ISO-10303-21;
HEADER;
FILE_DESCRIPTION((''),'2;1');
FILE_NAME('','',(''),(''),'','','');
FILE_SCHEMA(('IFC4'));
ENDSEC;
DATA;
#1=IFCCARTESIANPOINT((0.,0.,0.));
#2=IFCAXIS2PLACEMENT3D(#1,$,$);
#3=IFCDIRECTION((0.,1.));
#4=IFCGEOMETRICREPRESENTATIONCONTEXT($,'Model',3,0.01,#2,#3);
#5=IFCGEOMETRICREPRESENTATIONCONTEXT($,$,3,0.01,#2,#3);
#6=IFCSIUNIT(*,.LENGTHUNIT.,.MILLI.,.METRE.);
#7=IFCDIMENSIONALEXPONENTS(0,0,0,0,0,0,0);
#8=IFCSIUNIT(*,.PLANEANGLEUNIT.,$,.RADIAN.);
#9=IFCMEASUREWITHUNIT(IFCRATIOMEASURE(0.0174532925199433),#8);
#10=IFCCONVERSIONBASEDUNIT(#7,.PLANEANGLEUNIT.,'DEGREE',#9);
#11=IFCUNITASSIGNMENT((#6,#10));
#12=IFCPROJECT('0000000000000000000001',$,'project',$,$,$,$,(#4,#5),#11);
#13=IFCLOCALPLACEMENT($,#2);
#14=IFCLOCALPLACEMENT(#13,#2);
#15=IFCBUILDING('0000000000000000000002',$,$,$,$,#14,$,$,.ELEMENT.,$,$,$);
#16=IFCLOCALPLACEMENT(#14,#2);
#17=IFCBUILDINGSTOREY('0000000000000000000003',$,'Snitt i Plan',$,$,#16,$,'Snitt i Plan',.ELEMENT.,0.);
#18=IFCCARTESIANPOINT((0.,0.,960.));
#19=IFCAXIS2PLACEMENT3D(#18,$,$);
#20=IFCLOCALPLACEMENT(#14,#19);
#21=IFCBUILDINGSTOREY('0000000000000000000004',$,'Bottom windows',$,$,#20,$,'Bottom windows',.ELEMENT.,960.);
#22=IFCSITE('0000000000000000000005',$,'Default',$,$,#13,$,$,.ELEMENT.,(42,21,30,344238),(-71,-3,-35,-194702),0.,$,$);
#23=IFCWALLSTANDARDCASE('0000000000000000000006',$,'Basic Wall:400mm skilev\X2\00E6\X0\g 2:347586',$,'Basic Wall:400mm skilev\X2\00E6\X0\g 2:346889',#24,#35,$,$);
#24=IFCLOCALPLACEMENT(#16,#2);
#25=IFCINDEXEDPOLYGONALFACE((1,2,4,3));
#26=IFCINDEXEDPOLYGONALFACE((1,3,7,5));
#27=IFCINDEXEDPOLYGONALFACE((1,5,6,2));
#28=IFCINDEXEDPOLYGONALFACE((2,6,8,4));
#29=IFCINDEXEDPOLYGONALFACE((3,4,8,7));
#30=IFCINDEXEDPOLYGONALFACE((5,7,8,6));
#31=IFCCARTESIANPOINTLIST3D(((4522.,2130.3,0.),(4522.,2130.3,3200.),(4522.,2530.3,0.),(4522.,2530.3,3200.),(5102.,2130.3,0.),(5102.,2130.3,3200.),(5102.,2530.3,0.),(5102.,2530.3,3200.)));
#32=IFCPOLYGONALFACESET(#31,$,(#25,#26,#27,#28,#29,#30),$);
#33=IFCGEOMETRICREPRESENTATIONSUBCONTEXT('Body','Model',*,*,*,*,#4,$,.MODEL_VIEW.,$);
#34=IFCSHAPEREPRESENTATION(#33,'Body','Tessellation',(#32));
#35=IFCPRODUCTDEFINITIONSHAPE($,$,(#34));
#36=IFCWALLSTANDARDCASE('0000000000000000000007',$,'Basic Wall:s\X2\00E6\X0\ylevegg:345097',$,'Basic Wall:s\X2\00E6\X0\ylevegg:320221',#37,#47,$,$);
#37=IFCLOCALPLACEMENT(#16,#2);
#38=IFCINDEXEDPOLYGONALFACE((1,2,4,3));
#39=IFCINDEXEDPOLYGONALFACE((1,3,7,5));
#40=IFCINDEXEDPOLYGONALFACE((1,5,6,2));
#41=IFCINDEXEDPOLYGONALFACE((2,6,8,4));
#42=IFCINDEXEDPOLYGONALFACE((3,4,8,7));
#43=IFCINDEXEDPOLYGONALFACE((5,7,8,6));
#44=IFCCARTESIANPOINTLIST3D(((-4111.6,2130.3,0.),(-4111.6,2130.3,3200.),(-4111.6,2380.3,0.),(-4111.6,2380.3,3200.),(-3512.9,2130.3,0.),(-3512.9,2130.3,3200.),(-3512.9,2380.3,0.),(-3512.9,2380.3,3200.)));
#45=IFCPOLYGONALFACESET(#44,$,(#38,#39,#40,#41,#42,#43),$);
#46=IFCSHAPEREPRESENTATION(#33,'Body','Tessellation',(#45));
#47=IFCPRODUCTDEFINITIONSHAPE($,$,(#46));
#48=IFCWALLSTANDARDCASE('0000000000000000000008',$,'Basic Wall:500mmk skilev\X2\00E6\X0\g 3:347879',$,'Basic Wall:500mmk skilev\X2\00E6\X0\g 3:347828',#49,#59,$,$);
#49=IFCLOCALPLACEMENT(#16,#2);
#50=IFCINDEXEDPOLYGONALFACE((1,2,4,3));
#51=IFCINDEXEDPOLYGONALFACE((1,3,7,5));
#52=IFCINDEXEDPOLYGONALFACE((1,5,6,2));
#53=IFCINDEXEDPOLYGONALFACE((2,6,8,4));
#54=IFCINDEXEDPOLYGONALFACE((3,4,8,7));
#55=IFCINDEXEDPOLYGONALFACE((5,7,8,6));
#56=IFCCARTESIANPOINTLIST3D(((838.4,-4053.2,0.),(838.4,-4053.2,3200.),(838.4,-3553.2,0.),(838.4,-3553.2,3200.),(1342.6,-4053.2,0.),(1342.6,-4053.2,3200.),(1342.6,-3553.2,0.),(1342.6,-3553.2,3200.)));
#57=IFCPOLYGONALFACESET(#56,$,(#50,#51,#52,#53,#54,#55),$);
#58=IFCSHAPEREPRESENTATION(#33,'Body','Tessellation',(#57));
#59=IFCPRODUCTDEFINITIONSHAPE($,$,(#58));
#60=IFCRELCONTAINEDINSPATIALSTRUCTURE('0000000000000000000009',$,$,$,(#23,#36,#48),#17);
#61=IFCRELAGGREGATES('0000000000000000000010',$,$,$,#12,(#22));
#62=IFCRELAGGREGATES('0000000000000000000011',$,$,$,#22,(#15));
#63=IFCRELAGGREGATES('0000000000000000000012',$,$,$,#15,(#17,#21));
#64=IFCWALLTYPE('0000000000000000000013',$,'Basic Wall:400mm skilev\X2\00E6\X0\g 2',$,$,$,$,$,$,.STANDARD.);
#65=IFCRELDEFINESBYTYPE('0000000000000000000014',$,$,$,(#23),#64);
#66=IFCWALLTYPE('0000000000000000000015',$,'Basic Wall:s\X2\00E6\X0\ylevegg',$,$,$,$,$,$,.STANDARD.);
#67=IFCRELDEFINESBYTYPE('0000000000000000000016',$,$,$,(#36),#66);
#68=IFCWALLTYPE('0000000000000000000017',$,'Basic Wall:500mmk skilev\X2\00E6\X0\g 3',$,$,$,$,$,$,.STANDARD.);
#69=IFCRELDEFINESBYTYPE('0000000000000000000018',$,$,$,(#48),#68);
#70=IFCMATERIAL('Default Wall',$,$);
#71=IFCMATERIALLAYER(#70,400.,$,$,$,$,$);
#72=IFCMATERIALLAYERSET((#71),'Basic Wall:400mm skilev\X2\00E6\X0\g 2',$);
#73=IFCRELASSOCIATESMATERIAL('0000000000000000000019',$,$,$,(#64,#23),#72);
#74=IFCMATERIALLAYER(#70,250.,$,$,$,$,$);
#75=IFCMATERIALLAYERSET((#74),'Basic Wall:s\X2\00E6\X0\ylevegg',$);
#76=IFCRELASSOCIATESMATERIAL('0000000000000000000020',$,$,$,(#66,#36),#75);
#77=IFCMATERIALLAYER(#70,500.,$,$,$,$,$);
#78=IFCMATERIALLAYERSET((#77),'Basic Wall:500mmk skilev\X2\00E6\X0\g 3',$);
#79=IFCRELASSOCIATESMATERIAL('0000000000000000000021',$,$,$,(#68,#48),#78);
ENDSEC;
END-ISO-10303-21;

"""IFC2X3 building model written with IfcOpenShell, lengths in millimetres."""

from ifc_helpers import new_model, entity, si_unit, converted_unit, direction, frame, frame_2d, origin, place, context, subcontext, project, spatial, rectangle, extrude, material, layer, layer_set, layer_usage, type_object, element, save


model = new_model("IFC2X3")

# Units and contexts
model_context = context("Model", 3, precision=0.01, world=origin(), true_north=direction((0.0, 1.0)))
context_of_model = context(None, 3, precision=0.01, world=origin(), true_north=direction((0.0, 1.0)))
body_context = subcontext(model_context, "Body", "Model", "MODEL_VIEW")
ifc_project = project(units=[si_unit("LENGTHUNIT", "METRE", prefix="MILLI"), converted_unit("PLANEANGLEUNIT", "DEGREE", entity("IfcRatioMeasure", 0.0174532925199433), si_unit("PLANEANGLEUNIT", "RADIAN"), dimensions=[0, 0, 0, 0, 0, 0, 0])], contexts=[model_context, context_of_model])

# Site, building, storey
site_placement = place(None, origin())
site = spatial("IfcSite", under=ifc_project, at=site_placement, Name="Default", CompositionType="ELEMENT", RefLatitude=(42, 21, 30, 344238), RefLongitude=(-71, -3, -35, -194702), RefElevation=0.0)
building_placement = place(site_placement, origin())
building = spatial("IfcBuilding", under=site, at=building_placement, CompositionType="ELEMENT")
storey_1_placement = place(building_placement, origin())
storey_1 = spatial("IfcBuildingStorey", under=building, at=storey_1_placement, Name="Snitt i Plan", LongName="Snitt i Plan", CompositionType="ELEMENT", Elevation=0.0)

# Shared definitions
storey_2_placement = place(building_placement, frame((0.0, 0.0, 960.0)))
storey_2 = spatial("IfcBuildingStorey", under=building, at=storey_2_placement, Name="Bottom windows", LongName="Bottom windows", CompositionType="ELEMENT", Elevation=960.0)

# Walls
ifc_material_1 = material(Name="Default Wall")
ifc_layer_1 = layer(ifc_material_1, 400.0)
ifc_layer_set_1 = layer_set([ifc_layer_1], Name="Basic Wall:400mm skilevæg 2")
wall_type_1 = type_object("IfcWallType", Name="Basic Wall:400mm skilevæg 2", PredefinedType="STANDARD", material=ifc_layer_set_1)
ifc_layer_usage_1 = layer_usage(ifc_layer_set_1, "AXIS2", "NEGATIVE", 200.0)
wall_1_placement = place(storey_1_placement, frame((5102.0, 2330.3, 0.0), z_axis=(0.0, 0.0, 1.0), x_axis=(-1.0, 0.0, 0.0)))
element("IfcWallStandardCase", 1, at=wall_1_placement, inside=storey_1, type_object=wall_type_1, material=ifc_layer_usage_1, Name="Basic Wall:400mm skilevæg 2:347586", ObjectType="Basic Wall:400mm skilevæg 2:346889", context=body_context, shape_type="SweptSolid", body=[
    extrude(rectangle(XDim=580.0, YDim=400.0, at=frame_2d((290.0, 0.0), x_axis=(-1.0, 0.0))), origin(), (0.0, 0.0, 1.0), 3200.0),
])
ifc_layer_2 = layer(ifc_material_1, 250.0)
ifc_layer_set_2 = layer_set([ifc_layer_2], Name="Basic Wall:sæylevegg")
ifc_layer_usage_2 = layer_usage(ifc_layer_set_2, "AXIS2", "NEGATIVE", 125.0)
wall_type_2 = type_object("IfcWallType", Name="Basic Wall:sæylevegg", PredefinedType="STANDARD", material=ifc_layer_set_2)
wall_2_placement = place(storey_1_placement, frame((-4111.6, 2255.3, 0.0)))
element("IfcWallStandardCase", 2, at=wall_2_placement, inside=storey_1, type_object=wall_type_2, material=ifc_layer_usage_2, Name="Basic Wall:sæylevegg:345097", ObjectType="Basic Wall:sæylevegg:320221", context=body_context, shape_type="SweptSolid", body=[
    extrude(rectangle(XDim=598.7, YDim=250.0, at=frame_2d((299.3, 0.0), x_axis=(-1.0, 0.0))), origin(), (0.0, 0.0, 1.0), 3200.0),
])
ifc_layer_3 = layer(ifc_material_1, 500.0)
ifc_layer_set_3 = layer_set([ifc_layer_3], Name="Basic Wall:500mmk skilevæg 3")
ifc_layer_usage_3 = layer_usage(ifc_layer_set_3, "AXIS2", "NEGATIVE", 250.0)
wall_type_3 = type_object("IfcWallType", Name="Basic Wall:500mmk skilevæg 3", PredefinedType="STANDARD", material=ifc_layer_set_3)
wall_3_placement = place(storey_1_placement, frame((838.4, -3803.2, 0.0)))
element("IfcWallStandardCase", 3, at=wall_3_placement, inside=storey_1, type_object=wall_type_3, material=ifc_layer_usage_3, Name="Basic Wall:500mmk skilevæg 3:347879", ObjectType="Basic Wall:500mmk skilevæg 3:347828", context=body_context, shape_type="SweptSolid", body=[
    extrude(rectangle(XDim=504.2, YDim=500.0, at=frame_2d((252.1, 0.0), x_axis=(-1.0, 0.0))), origin(), (0.0, 0.0, 1.0), 3200.0),
])

save(model, "model.ifc")
